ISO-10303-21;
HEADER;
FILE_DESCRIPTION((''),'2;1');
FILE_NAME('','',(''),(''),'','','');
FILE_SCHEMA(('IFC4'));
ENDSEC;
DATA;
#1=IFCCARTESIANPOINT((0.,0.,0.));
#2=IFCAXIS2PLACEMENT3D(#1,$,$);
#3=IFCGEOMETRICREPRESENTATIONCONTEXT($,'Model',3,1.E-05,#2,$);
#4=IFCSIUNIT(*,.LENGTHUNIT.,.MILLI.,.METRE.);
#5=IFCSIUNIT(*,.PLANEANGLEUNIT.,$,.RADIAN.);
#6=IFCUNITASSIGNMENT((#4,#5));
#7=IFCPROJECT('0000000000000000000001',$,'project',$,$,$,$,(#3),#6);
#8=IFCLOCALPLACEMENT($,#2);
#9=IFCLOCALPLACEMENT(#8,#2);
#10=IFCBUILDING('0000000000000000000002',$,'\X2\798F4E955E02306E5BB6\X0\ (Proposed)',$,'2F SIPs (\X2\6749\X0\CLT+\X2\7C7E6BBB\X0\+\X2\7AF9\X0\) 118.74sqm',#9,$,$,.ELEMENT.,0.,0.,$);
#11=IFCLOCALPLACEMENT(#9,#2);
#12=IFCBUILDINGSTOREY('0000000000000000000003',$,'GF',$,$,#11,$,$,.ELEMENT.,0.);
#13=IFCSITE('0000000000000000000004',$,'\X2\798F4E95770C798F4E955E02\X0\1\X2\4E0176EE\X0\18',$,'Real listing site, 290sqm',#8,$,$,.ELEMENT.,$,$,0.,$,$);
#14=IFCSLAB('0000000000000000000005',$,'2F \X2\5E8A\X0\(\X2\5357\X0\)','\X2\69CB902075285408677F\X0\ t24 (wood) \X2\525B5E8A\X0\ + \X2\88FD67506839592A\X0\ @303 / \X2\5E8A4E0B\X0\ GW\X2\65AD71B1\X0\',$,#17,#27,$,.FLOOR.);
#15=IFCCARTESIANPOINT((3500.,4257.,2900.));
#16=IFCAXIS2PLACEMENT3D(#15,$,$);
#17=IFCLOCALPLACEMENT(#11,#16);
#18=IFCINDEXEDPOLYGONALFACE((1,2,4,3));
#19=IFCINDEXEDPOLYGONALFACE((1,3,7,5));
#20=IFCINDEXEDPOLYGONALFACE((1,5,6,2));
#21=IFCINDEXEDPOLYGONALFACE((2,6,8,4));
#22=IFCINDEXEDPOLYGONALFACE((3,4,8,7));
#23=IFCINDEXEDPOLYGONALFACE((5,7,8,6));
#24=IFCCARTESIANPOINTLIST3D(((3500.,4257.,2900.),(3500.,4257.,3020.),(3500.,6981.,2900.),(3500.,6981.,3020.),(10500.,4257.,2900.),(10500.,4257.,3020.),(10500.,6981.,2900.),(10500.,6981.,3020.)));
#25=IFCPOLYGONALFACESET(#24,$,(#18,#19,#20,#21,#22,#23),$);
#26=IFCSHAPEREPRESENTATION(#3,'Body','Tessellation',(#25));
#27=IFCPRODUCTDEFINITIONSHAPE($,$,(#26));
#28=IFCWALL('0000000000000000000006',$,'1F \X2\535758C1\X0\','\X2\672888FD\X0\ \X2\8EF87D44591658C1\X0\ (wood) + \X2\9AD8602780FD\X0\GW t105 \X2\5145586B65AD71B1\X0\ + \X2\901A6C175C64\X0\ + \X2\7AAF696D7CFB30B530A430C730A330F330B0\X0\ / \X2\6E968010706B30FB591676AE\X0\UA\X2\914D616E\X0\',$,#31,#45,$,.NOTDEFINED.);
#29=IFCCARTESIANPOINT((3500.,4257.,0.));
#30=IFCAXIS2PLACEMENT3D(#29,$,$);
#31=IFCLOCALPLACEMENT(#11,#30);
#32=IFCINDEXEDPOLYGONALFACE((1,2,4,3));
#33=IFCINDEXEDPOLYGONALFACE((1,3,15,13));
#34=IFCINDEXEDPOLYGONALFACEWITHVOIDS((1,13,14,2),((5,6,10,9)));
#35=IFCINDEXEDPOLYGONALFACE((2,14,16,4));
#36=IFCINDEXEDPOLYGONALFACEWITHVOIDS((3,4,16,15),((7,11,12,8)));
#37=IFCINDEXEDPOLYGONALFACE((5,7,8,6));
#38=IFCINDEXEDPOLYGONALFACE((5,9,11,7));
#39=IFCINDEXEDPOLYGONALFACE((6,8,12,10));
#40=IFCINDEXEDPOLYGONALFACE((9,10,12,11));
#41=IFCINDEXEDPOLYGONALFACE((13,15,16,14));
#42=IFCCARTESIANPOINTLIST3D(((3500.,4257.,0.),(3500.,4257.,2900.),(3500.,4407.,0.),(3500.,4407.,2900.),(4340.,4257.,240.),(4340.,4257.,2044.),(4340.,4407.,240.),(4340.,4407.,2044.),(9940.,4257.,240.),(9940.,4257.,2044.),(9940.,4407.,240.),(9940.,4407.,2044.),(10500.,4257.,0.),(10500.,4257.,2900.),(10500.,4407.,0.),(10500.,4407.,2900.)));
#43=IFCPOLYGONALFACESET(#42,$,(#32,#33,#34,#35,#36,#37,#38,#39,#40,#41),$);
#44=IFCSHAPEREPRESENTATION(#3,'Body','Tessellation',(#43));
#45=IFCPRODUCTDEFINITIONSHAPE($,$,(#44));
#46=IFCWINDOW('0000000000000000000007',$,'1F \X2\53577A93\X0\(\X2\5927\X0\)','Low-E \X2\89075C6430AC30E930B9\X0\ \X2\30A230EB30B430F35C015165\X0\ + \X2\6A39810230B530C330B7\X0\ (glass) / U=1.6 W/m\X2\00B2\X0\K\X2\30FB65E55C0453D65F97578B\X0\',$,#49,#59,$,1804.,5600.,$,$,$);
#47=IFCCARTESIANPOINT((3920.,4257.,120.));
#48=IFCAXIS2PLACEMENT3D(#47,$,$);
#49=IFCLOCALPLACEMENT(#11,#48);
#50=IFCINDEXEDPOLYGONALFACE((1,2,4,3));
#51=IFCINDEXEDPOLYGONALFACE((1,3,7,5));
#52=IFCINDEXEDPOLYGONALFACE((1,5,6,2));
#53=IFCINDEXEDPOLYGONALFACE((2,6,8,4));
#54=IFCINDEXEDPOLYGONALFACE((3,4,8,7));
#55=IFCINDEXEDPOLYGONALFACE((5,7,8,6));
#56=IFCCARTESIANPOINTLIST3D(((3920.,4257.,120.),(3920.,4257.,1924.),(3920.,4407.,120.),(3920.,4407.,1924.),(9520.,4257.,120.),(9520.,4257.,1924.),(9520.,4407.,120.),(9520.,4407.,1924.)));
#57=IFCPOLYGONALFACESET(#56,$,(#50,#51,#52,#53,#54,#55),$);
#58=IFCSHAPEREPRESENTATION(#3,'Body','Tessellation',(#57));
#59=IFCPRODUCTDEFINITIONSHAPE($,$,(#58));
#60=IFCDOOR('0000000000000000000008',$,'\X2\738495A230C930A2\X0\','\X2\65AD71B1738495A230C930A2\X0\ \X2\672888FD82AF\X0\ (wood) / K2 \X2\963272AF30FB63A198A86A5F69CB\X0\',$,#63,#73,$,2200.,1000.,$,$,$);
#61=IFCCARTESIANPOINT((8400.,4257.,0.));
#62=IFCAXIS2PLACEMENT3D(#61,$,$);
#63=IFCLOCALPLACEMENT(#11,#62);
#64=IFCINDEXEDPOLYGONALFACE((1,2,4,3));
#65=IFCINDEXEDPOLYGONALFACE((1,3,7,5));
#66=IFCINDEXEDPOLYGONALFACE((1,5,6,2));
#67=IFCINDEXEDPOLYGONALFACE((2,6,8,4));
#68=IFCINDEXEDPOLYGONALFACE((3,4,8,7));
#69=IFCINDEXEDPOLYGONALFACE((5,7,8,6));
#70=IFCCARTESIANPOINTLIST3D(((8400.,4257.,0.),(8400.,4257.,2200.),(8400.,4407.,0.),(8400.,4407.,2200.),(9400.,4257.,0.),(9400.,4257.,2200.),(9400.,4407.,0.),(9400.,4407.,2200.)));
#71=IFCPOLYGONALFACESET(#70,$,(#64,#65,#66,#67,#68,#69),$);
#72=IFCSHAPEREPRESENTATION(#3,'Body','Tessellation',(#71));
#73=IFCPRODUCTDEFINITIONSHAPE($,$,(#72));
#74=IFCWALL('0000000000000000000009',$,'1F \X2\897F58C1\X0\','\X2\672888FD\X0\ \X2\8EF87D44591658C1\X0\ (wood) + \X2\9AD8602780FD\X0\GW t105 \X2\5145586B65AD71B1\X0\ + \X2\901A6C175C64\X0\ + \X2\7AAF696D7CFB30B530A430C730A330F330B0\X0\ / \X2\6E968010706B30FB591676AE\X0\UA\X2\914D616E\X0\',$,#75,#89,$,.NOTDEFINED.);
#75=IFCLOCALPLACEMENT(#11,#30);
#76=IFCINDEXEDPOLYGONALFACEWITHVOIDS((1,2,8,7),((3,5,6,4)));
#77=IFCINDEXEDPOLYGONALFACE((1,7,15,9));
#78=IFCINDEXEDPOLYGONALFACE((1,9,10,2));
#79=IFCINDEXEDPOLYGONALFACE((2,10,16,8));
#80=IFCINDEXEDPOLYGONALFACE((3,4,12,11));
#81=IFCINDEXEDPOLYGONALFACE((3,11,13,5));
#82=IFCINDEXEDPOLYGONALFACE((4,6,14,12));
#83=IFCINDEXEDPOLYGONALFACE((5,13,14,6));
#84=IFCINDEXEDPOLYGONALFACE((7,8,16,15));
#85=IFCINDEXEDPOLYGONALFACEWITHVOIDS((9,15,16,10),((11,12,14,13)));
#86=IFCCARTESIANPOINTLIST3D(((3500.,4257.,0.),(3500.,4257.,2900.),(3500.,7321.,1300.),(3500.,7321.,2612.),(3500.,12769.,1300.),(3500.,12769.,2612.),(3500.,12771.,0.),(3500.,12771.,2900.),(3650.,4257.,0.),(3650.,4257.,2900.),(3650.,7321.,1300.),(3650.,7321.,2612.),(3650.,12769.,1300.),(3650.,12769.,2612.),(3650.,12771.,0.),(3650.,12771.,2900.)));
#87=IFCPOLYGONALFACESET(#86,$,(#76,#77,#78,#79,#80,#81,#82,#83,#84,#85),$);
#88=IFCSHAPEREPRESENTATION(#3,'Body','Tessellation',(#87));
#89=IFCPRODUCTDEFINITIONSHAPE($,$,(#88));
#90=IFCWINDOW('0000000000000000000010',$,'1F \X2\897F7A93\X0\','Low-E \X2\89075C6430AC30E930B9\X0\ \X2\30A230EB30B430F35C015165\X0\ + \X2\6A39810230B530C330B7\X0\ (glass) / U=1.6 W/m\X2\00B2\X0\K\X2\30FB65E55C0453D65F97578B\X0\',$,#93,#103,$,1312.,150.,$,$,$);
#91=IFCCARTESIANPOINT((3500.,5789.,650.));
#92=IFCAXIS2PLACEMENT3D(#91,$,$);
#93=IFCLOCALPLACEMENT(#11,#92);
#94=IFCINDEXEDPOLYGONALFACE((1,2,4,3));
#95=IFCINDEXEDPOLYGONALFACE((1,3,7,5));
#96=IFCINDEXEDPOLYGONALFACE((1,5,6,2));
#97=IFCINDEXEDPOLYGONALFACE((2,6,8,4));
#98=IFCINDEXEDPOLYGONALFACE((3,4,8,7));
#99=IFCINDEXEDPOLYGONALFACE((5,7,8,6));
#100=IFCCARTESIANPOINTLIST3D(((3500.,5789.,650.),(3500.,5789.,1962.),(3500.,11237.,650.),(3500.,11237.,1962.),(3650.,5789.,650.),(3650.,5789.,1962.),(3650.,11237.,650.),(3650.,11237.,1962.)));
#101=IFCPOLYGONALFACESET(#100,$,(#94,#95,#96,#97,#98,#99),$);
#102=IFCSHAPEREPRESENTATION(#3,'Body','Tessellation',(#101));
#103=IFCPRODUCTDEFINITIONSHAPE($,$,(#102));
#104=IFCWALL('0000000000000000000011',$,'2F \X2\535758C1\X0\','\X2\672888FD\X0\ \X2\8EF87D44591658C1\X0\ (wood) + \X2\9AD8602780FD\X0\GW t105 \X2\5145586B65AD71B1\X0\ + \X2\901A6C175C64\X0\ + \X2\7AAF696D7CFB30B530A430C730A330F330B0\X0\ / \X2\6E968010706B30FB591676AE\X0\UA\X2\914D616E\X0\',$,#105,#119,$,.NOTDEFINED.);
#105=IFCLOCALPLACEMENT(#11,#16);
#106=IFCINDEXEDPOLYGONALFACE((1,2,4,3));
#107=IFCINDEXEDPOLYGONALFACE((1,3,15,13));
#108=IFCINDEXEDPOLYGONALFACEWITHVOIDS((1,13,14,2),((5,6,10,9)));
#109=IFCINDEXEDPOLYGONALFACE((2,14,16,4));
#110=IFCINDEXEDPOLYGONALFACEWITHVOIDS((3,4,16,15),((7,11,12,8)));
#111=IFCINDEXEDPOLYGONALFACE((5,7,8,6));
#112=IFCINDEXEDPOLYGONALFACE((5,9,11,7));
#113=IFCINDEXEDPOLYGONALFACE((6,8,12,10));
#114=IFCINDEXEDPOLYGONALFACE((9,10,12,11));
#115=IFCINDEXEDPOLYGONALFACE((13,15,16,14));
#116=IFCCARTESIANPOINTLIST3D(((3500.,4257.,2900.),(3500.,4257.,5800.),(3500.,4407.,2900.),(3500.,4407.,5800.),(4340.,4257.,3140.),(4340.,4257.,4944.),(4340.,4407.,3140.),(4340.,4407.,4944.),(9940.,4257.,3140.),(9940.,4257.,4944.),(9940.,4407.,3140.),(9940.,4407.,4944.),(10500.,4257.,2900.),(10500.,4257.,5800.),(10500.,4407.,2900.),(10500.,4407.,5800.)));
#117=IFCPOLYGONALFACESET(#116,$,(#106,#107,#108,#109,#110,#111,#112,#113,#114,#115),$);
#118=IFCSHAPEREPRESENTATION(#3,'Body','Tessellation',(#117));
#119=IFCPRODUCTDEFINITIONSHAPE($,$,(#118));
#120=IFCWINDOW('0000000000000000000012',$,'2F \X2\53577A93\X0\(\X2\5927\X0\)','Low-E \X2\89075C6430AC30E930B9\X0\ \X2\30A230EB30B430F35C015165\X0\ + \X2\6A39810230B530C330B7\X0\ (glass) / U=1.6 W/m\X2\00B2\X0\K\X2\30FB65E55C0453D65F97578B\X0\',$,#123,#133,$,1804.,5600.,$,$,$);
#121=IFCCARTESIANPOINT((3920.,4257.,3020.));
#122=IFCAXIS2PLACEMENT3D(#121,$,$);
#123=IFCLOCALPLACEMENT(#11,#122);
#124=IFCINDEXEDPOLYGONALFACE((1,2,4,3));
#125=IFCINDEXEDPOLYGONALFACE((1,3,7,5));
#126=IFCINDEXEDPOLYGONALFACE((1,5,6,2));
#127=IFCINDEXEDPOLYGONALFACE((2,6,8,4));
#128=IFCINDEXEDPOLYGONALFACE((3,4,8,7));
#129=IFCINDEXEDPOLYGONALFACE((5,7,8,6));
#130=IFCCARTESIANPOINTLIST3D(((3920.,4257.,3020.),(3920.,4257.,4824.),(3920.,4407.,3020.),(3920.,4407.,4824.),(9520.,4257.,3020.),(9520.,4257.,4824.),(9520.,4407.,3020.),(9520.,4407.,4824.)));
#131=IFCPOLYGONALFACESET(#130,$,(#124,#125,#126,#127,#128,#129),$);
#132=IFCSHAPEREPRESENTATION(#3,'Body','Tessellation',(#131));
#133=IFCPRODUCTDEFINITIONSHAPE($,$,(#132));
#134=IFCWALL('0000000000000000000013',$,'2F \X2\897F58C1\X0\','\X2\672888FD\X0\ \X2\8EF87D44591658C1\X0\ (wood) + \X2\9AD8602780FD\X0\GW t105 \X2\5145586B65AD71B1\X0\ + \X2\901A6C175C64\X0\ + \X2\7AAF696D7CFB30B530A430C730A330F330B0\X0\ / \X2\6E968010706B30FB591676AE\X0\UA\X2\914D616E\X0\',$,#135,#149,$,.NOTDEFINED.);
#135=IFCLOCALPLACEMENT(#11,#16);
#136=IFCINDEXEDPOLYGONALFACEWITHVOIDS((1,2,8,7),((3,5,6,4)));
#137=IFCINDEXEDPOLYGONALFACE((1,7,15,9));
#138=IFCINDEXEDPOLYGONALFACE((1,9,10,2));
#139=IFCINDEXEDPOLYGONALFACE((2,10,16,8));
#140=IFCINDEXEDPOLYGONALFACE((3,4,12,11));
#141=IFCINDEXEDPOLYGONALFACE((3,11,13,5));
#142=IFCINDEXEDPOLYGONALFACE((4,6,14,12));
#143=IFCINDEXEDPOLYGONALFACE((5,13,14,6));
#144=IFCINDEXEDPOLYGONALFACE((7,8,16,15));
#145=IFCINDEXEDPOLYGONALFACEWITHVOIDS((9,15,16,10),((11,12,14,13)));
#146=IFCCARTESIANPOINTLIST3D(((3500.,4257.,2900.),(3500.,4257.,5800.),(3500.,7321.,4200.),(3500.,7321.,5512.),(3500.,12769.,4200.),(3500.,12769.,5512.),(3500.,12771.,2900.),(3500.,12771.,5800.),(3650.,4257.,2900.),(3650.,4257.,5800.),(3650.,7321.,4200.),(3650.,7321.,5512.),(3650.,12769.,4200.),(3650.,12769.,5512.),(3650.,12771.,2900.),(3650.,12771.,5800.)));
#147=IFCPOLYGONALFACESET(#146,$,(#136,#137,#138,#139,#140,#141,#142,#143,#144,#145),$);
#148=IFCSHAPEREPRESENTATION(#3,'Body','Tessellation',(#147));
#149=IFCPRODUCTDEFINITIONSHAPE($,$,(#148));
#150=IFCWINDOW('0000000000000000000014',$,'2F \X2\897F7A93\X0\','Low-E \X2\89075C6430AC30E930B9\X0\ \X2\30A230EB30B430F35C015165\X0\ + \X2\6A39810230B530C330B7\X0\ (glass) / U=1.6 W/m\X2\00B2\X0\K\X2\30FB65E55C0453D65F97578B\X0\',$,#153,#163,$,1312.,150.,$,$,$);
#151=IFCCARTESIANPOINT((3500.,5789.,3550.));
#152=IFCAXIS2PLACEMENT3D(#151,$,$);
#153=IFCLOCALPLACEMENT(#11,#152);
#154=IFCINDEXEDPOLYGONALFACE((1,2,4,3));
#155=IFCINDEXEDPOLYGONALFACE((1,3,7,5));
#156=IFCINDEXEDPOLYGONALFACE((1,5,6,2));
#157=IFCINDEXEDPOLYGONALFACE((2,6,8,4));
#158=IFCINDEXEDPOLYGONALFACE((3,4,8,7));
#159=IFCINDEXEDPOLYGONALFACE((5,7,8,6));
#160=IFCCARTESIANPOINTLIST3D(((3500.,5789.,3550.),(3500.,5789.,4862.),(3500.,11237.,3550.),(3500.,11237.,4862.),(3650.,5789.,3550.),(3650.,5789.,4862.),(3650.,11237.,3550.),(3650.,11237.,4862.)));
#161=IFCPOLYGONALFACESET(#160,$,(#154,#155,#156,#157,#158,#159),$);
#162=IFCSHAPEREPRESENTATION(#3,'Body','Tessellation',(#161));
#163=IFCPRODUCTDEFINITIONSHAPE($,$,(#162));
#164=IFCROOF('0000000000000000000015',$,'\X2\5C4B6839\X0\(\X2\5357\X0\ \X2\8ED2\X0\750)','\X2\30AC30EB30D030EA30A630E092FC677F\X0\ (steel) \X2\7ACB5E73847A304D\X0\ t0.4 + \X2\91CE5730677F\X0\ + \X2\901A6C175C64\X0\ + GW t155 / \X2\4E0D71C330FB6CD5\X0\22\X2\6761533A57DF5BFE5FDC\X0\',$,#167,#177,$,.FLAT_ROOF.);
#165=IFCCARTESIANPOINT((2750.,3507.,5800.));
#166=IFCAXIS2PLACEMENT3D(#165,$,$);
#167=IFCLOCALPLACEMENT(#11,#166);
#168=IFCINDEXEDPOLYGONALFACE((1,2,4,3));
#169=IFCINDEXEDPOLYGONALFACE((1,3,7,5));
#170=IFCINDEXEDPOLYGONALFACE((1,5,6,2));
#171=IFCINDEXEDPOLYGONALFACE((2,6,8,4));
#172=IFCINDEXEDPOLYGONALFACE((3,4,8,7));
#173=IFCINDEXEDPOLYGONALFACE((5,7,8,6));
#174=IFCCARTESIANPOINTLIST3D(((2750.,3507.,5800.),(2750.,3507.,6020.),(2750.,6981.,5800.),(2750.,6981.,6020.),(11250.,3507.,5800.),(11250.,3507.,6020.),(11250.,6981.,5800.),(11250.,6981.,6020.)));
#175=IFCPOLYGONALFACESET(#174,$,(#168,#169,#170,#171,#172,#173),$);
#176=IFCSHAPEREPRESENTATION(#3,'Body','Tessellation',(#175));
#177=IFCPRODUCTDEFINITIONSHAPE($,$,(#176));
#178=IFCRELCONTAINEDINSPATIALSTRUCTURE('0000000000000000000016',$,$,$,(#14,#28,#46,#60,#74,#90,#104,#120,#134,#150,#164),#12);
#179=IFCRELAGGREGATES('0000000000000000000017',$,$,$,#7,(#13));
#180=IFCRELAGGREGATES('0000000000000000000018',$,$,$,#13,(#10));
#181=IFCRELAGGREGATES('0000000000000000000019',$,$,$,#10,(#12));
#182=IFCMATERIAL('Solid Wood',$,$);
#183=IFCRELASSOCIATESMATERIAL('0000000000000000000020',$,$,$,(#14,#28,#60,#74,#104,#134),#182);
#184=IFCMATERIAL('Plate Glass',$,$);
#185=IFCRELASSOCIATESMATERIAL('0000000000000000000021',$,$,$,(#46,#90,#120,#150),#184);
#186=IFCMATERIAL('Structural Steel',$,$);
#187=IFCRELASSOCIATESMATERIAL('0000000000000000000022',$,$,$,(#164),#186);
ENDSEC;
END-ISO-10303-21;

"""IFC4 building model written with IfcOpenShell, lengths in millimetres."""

from ifc_helpers import new_model, si_unit, frame, frame_2d, origin, place, context, project, spatial, rectangle, extrude, material, element, fill, save


model = new_model("IFC4")

# Units and contexts
model_context = context("Model", 3, precision=1e-05, world=origin())
ifc_project = project(units=[si_unit("LENGTHUNIT", "METRE", prefix="MILLI"), si_unit("PLANEANGLEUNIT", "RADIAN")], contexts=[model_context])

# Site, building, storey
site_placement = place(None, origin())
site = spatial("IfcSite", under=ifc_project, at=site_placement, Name="福井県福井市1丁目18", ObjectType="Real listing site, 290sqm", CompositionType="ELEMENT", RefElevation=0.0)
building_placement = place(site_placement, origin())
building = spatial("IfcBuilding", under=site, at=building_placement, Name="福井市の家 (Proposed)", ObjectType="2F SIPs (杉CLT+籾殻+竹) 118.74sqm", CompositionType="ELEMENT", ElevationOfRefHeight=0.0, ElevationOfTerrain=0.0)
storey_placement = place(building_placement, origin())
storey = spatial("IfcBuildingStorey", under=building, at=storey_placement, Name="GF", CompositionType="ELEMENT", Elevation=0.0)

# Slab
ifc_material_1 = material(Name="Solid Wood")
slab_1_placement = place(storey_placement, frame((3500.0, 4257.0, 2900.0)))
element("IfcSlab", 1, at=slab_1_placement, inside=storey, material=ifc_material_1, Name="2F 床(南)", Description="構造用合板 t24 (wood) 剛床 + 製材根太 @303 / 床下 GW断熱", PredefinedType="FLOOR", context=model_context, shape_type="SweptSolid", body=[
    extrude(rectangle(XDim=7000.0, YDim=2724.0, at=frame_2d((3500.0, 1362.0))), frame((3500.0, 4257.0, 2900.0)), (0.0, 0.0, 1.0), 120.0),
])

# Wall, openings, window, door
wall_1_placement = place(storey_placement, frame((3500.0, 4257.0, 0.0)))
wall_1 = element("IfcWall", 2, at=wall_1_placement, inside=storey, material=ifc_material_1, Name="1F 南壁", Description="木製 軸組外壁 (wood) + 高性能GW t105 充填断熱 + 通気層 + 窯業系サイディング / 準耐火・外皮UA配慮", PredefinedType="NOTDEFINED", context=model_context, shape_type="SweptSolid", body=[
    extrude(rectangle(XDim=7000.0, YDim=150.0, at=frame_2d((3500.0, 75.0))), frame((3500.0, 4257.0, 0.0)), (0.0, 0.0, 1.0), 2900.0),
])
opening_1_placement = place(storey_placement, frame((3920.0, 4257.0, 120.0)))
opening_1 = element("IfcOpeningElement", 3, at=opening_1_placement, cuts=wall_1, PredefinedType="NOTDEFINED", context=model_context, shape_type="SweptSolid", body=[
    extrude(rectangle(XDim=5600.0, YDim=150.0, at=frame_2d((2800.0, 75.0))), frame((3920.0, 4257.0, 120.0)), (0.0, 0.0, 1.0), 1804.0),
])
opening_2_placement = place(storey_placement, frame((8400.0, 4257.0, 0.0)))
opening_2 = element("IfcOpeningElement", 4, at=opening_2_placement, cuts=wall_1, PredefinedType="NOTDEFINED", context=model_context, shape_type="SweptSolid", body=[
    extrude(rectangle(XDim=1000.0, YDim=150.0, at=frame_2d((500.0, 75.0))), frame((8400.0, 4257.0, 0.0)), (0.0, 0.0, 1.0), 2200.0),
])
ifc_material_2 = material(Name="Plate Glass")
window_1_placement = place(storey_placement, frame((3920.0, 4257.0, 120.0)))
window_1 = element("IfcWindow", 5, at=window_1_placement, inside=storey, material=ifc_material_2, Name="1F 南窓(大)", Description="Low-E 複層ガラス アルゴン封入 + 樹脂サッシ (glass) / U=1.6 W/m²K・日射取得型", OverallHeight=1804.0, OverallWidth=5600.0, context=model_context, shape_type="SweptSolid", body=[
    extrude(rectangle(XDim=5600.0, YDim=150.0, at=frame_2d((2800.0, 75.0))), frame((3920.0, 4257.0, 120.0)), (0.0, 0.0, 1.0), 1804.0),
])
fill(opening_1, window_1)
door_placement = place(storey_placement, frame((8400.0, 4257.0, 0.0)))
door = element("IfcDoor", 6, at=door_placement, inside=storey, material=ifc_material_1, Name="玄関ドア", Description="断熱玄関ドア 木製芯 (wood) / K2 防犯・採風機構", OverallHeight=2200.0, OverallWidth=1000.0, context=model_context, shape_type="SweptSolid", body=[
    extrude(rectangle(XDim=1000.0, YDim=150.0, at=frame_2d((500.0, 75.0))), frame((8400.0, 4257.0, 0.0)), (0.0, 0.0, 1.0), 2200.0),
])
fill(opening_2, door)

# Walls, openings, windows
wall_2_placement = place(storey_placement, frame((3500.0, 4257.0, 0.0)))
wall_2 = element("IfcWall", 7, at=wall_2_placement, inside=storey, material=ifc_material_1, Name="1F 西壁", Description="木製 軸組外壁 (wood) + 高性能GW t105 充填断熱 + 通気層 + 窯業系サイディング / 準耐火・外皮UA配慮", PredefinedType="NOTDEFINED", context=model_context, shape_type="SweptSolid", body=[
    extrude(rectangle(XDim=150.0, YDim=8514.0, at=frame_2d((75.0, 4257.0))), frame((3500.0, 4257.0, 0.0)), (0.0, 0.0, 1.0), 2900.0),
])
opening_3_placement = place(storey_placement, frame((3500.0, 5789.0, 650.0)))
opening_3 = element("IfcOpeningElement", 8, at=opening_3_placement, cuts=wall_2, PredefinedType="NOTDEFINED", context=model_context, shape_type="SweptSolid", body=[
    extrude(rectangle(XDim=150.0, YDim=5448.0, at=frame_2d((75.0, 2724.0))), frame((3500.0, 5789.0, 650.0)), (0.0, 0.0, 1.0), 1312.0),
])
window_2_placement = place(storey_placement, frame((3500.0, 5789.0, 650.0)))
window_2 = element("IfcWindow", 9, at=window_2_placement, inside=storey, material=ifc_material_2, Name="1F 西窓", Description="Low-E 複層ガラス アルゴン封入 + 樹脂サッシ (glass) / U=1.6 W/m²K・日射取得型", OverallHeight=1312.0, OverallWidth=150.0, context=model_context, shape_type="SweptSolid", body=[
    extrude(rectangle(XDim=150.0, YDim=5448.0, at=frame_2d((75.0, 2724.0))), frame((3500.0, 5789.0, 650.0)), (0.0, 0.0, 1.0), 1312.0),
])
fill(opening_3, window_2)
wall_3_placement = place(storey_placement, frame((3500.0, 4257.0, 2900.0)))
wall_3 = element("IfcWall", 10, at=wall_3_placement, inside=storey, material=ifc_material_1, Name="2F 南壁", Description="木製 軸組外壁 (wood) + 高性能GW t105 充填断熱 + 通気層 + 窯業系サイディング / 準耐火・外皮UA配慮", PredefinedType="NOTDEFINED", context=model_context, shape_type="SweptSolid", body=[
    extrude(rectangle(XDim=7000.0, YDim=150.0, at=frame_2d((3500.0, 75.0))), frame((3500.0, 4257.0, 2900.0)), (0.0, 0.0, 1.0), 2900.0),
])
opening_4_placement = place(storey_placement, frame((3920.0, 4257.0, 3020.0)))
opening_4 = element("IfcOpeningElement", 11, at=opening_4_placement, cuts=wall_3, PredefinedType="NOTDEFINED", context=model_context, shape_type="SweptSolid", body=[
    extrude(rectangle(XDim=5600.0, YDim=150.0, at=frame_2d((2800.0, 75.0))), frame((3920.0, 4257.0, 3020.0)), (0.0, 0.0, 1.0), 1804.0),
])
window_3_placement = place(storey_placement, frame((3920.0, 4257.0, 3020.0)))
window_3 = element("IfcWindow", 12, at=window_3_placement, inside=storey, material=ifc_material_2, Name="2F 南窓(大)", Description="Low-E 複層ガラス アルゴン封入 + 樹脂サッシ (glass) / U=1.6 W/m²K・日射取得型", OverallHeight=1804.0, OverallWidth=5600.0, context=model_context, shape_type="SweptSolid", body=[
    extrude(rectangle(XDim=5600.0, YDim=150.0, at=frame_2d((2800.0, 75.0))), frame((3920.0, 4257.0, 3020.0)), (0.0, 0.0, 1.0), 1804.0),
])
fill(opening_4, window_3)
wall_4_placement = place(storey_placement, frame((3500.0, 4257.0, 2900.0)))
wall_4 = element("IfcWall", 13, at=wall_4_placement, inside=storey, material=ifc_material_1, Name="2F 西壁", Description="木製 軸組外壁 (wood) + 高性能GW t105 充填断熱 + 通気層 + 窯業系サイディング / 準耐火・外皮UA配慮", PredefinedType="NOTDEFINED", context=model_context, shape_type="SweptSolid", body=[
    extrude(rectangle(XDim=150.0, YDim=8514.0, at=frame_2d((75.0, 4257.0))), frame((3500.0, 4257.0, 2900.0)), (0.0, 0.0, 1.0), 2900.0),
])
opening_5_placement = place(storey_placement, frame((3500.0, 5789.0, 3550.0)))
opening_5 = element("IfcOpeningElement", 14, at=opening_5_placement, cuts=wall_4, PredefinedType="NOTDEFINED", context=model_context, shape_type="SweptSolid", body=[
    extrude(rectangle(XDim=150.0, YDim=5448.0, at=frame_2d((75.0, 2724.0))), frame((3500.0, 5789.0, 3550.0)), (0.0, 0.0, 1.0), 1312.0),
])
window_4_placement = place(storey_placement, frame((3500.0, 5789.0, 3550.0)))
window_4 = element("IfcWindow", 15, at=window_4_placement, inside=storey, material=ifc_material_2, Name="2F 西窓", Description="Low-E 複層ガラス アルゴン封入 + 樹脂サッシ (glass) / U=1.6 W/m²K・日射取得型", OverallHeight=1312.0, OverallWidth=150.0, context=model_context, shape_type="SweptSolid", body=[
    extrude(rectangle(XDim=150.0, YDim=5448.0, at=frame_2d((75.0, 2724.0))), frame((3500.0, 5789.0, 3550.0)), (0.0, 0.0, 1.0), 1312.0),
])
fill(opening_5, window_4)

# Roof
ifc_material_3 = material(Name="Structural Steel")
roof_1_placement = place(storey_placement, frame((2750.0, 3507.0, 5800.0)))
element("IfcRoof", 16, at=roof_1_placement, inside=storey, material=ifc_material_3, Name="屋根(南 軒750)", Description="ガルバリウム鋼板 (steel) 立平葺き t0.4 + 野地板 + 通気層 + GW t155 / 不燃・法22条区域対応", PredefinedType="FLAT_ROOF", context=model_context, shape_type="SweptSolid", body=[
    extrude(rectangle(XDim=8500.0, YDim=3474.0, at=frame_2d((4250.0, 1737.0))), frame((2750.0, 3507.0, 5800.0)), (0.0, 0.0, 1.0), 220.0),
])

save(model, "model.ifc")
